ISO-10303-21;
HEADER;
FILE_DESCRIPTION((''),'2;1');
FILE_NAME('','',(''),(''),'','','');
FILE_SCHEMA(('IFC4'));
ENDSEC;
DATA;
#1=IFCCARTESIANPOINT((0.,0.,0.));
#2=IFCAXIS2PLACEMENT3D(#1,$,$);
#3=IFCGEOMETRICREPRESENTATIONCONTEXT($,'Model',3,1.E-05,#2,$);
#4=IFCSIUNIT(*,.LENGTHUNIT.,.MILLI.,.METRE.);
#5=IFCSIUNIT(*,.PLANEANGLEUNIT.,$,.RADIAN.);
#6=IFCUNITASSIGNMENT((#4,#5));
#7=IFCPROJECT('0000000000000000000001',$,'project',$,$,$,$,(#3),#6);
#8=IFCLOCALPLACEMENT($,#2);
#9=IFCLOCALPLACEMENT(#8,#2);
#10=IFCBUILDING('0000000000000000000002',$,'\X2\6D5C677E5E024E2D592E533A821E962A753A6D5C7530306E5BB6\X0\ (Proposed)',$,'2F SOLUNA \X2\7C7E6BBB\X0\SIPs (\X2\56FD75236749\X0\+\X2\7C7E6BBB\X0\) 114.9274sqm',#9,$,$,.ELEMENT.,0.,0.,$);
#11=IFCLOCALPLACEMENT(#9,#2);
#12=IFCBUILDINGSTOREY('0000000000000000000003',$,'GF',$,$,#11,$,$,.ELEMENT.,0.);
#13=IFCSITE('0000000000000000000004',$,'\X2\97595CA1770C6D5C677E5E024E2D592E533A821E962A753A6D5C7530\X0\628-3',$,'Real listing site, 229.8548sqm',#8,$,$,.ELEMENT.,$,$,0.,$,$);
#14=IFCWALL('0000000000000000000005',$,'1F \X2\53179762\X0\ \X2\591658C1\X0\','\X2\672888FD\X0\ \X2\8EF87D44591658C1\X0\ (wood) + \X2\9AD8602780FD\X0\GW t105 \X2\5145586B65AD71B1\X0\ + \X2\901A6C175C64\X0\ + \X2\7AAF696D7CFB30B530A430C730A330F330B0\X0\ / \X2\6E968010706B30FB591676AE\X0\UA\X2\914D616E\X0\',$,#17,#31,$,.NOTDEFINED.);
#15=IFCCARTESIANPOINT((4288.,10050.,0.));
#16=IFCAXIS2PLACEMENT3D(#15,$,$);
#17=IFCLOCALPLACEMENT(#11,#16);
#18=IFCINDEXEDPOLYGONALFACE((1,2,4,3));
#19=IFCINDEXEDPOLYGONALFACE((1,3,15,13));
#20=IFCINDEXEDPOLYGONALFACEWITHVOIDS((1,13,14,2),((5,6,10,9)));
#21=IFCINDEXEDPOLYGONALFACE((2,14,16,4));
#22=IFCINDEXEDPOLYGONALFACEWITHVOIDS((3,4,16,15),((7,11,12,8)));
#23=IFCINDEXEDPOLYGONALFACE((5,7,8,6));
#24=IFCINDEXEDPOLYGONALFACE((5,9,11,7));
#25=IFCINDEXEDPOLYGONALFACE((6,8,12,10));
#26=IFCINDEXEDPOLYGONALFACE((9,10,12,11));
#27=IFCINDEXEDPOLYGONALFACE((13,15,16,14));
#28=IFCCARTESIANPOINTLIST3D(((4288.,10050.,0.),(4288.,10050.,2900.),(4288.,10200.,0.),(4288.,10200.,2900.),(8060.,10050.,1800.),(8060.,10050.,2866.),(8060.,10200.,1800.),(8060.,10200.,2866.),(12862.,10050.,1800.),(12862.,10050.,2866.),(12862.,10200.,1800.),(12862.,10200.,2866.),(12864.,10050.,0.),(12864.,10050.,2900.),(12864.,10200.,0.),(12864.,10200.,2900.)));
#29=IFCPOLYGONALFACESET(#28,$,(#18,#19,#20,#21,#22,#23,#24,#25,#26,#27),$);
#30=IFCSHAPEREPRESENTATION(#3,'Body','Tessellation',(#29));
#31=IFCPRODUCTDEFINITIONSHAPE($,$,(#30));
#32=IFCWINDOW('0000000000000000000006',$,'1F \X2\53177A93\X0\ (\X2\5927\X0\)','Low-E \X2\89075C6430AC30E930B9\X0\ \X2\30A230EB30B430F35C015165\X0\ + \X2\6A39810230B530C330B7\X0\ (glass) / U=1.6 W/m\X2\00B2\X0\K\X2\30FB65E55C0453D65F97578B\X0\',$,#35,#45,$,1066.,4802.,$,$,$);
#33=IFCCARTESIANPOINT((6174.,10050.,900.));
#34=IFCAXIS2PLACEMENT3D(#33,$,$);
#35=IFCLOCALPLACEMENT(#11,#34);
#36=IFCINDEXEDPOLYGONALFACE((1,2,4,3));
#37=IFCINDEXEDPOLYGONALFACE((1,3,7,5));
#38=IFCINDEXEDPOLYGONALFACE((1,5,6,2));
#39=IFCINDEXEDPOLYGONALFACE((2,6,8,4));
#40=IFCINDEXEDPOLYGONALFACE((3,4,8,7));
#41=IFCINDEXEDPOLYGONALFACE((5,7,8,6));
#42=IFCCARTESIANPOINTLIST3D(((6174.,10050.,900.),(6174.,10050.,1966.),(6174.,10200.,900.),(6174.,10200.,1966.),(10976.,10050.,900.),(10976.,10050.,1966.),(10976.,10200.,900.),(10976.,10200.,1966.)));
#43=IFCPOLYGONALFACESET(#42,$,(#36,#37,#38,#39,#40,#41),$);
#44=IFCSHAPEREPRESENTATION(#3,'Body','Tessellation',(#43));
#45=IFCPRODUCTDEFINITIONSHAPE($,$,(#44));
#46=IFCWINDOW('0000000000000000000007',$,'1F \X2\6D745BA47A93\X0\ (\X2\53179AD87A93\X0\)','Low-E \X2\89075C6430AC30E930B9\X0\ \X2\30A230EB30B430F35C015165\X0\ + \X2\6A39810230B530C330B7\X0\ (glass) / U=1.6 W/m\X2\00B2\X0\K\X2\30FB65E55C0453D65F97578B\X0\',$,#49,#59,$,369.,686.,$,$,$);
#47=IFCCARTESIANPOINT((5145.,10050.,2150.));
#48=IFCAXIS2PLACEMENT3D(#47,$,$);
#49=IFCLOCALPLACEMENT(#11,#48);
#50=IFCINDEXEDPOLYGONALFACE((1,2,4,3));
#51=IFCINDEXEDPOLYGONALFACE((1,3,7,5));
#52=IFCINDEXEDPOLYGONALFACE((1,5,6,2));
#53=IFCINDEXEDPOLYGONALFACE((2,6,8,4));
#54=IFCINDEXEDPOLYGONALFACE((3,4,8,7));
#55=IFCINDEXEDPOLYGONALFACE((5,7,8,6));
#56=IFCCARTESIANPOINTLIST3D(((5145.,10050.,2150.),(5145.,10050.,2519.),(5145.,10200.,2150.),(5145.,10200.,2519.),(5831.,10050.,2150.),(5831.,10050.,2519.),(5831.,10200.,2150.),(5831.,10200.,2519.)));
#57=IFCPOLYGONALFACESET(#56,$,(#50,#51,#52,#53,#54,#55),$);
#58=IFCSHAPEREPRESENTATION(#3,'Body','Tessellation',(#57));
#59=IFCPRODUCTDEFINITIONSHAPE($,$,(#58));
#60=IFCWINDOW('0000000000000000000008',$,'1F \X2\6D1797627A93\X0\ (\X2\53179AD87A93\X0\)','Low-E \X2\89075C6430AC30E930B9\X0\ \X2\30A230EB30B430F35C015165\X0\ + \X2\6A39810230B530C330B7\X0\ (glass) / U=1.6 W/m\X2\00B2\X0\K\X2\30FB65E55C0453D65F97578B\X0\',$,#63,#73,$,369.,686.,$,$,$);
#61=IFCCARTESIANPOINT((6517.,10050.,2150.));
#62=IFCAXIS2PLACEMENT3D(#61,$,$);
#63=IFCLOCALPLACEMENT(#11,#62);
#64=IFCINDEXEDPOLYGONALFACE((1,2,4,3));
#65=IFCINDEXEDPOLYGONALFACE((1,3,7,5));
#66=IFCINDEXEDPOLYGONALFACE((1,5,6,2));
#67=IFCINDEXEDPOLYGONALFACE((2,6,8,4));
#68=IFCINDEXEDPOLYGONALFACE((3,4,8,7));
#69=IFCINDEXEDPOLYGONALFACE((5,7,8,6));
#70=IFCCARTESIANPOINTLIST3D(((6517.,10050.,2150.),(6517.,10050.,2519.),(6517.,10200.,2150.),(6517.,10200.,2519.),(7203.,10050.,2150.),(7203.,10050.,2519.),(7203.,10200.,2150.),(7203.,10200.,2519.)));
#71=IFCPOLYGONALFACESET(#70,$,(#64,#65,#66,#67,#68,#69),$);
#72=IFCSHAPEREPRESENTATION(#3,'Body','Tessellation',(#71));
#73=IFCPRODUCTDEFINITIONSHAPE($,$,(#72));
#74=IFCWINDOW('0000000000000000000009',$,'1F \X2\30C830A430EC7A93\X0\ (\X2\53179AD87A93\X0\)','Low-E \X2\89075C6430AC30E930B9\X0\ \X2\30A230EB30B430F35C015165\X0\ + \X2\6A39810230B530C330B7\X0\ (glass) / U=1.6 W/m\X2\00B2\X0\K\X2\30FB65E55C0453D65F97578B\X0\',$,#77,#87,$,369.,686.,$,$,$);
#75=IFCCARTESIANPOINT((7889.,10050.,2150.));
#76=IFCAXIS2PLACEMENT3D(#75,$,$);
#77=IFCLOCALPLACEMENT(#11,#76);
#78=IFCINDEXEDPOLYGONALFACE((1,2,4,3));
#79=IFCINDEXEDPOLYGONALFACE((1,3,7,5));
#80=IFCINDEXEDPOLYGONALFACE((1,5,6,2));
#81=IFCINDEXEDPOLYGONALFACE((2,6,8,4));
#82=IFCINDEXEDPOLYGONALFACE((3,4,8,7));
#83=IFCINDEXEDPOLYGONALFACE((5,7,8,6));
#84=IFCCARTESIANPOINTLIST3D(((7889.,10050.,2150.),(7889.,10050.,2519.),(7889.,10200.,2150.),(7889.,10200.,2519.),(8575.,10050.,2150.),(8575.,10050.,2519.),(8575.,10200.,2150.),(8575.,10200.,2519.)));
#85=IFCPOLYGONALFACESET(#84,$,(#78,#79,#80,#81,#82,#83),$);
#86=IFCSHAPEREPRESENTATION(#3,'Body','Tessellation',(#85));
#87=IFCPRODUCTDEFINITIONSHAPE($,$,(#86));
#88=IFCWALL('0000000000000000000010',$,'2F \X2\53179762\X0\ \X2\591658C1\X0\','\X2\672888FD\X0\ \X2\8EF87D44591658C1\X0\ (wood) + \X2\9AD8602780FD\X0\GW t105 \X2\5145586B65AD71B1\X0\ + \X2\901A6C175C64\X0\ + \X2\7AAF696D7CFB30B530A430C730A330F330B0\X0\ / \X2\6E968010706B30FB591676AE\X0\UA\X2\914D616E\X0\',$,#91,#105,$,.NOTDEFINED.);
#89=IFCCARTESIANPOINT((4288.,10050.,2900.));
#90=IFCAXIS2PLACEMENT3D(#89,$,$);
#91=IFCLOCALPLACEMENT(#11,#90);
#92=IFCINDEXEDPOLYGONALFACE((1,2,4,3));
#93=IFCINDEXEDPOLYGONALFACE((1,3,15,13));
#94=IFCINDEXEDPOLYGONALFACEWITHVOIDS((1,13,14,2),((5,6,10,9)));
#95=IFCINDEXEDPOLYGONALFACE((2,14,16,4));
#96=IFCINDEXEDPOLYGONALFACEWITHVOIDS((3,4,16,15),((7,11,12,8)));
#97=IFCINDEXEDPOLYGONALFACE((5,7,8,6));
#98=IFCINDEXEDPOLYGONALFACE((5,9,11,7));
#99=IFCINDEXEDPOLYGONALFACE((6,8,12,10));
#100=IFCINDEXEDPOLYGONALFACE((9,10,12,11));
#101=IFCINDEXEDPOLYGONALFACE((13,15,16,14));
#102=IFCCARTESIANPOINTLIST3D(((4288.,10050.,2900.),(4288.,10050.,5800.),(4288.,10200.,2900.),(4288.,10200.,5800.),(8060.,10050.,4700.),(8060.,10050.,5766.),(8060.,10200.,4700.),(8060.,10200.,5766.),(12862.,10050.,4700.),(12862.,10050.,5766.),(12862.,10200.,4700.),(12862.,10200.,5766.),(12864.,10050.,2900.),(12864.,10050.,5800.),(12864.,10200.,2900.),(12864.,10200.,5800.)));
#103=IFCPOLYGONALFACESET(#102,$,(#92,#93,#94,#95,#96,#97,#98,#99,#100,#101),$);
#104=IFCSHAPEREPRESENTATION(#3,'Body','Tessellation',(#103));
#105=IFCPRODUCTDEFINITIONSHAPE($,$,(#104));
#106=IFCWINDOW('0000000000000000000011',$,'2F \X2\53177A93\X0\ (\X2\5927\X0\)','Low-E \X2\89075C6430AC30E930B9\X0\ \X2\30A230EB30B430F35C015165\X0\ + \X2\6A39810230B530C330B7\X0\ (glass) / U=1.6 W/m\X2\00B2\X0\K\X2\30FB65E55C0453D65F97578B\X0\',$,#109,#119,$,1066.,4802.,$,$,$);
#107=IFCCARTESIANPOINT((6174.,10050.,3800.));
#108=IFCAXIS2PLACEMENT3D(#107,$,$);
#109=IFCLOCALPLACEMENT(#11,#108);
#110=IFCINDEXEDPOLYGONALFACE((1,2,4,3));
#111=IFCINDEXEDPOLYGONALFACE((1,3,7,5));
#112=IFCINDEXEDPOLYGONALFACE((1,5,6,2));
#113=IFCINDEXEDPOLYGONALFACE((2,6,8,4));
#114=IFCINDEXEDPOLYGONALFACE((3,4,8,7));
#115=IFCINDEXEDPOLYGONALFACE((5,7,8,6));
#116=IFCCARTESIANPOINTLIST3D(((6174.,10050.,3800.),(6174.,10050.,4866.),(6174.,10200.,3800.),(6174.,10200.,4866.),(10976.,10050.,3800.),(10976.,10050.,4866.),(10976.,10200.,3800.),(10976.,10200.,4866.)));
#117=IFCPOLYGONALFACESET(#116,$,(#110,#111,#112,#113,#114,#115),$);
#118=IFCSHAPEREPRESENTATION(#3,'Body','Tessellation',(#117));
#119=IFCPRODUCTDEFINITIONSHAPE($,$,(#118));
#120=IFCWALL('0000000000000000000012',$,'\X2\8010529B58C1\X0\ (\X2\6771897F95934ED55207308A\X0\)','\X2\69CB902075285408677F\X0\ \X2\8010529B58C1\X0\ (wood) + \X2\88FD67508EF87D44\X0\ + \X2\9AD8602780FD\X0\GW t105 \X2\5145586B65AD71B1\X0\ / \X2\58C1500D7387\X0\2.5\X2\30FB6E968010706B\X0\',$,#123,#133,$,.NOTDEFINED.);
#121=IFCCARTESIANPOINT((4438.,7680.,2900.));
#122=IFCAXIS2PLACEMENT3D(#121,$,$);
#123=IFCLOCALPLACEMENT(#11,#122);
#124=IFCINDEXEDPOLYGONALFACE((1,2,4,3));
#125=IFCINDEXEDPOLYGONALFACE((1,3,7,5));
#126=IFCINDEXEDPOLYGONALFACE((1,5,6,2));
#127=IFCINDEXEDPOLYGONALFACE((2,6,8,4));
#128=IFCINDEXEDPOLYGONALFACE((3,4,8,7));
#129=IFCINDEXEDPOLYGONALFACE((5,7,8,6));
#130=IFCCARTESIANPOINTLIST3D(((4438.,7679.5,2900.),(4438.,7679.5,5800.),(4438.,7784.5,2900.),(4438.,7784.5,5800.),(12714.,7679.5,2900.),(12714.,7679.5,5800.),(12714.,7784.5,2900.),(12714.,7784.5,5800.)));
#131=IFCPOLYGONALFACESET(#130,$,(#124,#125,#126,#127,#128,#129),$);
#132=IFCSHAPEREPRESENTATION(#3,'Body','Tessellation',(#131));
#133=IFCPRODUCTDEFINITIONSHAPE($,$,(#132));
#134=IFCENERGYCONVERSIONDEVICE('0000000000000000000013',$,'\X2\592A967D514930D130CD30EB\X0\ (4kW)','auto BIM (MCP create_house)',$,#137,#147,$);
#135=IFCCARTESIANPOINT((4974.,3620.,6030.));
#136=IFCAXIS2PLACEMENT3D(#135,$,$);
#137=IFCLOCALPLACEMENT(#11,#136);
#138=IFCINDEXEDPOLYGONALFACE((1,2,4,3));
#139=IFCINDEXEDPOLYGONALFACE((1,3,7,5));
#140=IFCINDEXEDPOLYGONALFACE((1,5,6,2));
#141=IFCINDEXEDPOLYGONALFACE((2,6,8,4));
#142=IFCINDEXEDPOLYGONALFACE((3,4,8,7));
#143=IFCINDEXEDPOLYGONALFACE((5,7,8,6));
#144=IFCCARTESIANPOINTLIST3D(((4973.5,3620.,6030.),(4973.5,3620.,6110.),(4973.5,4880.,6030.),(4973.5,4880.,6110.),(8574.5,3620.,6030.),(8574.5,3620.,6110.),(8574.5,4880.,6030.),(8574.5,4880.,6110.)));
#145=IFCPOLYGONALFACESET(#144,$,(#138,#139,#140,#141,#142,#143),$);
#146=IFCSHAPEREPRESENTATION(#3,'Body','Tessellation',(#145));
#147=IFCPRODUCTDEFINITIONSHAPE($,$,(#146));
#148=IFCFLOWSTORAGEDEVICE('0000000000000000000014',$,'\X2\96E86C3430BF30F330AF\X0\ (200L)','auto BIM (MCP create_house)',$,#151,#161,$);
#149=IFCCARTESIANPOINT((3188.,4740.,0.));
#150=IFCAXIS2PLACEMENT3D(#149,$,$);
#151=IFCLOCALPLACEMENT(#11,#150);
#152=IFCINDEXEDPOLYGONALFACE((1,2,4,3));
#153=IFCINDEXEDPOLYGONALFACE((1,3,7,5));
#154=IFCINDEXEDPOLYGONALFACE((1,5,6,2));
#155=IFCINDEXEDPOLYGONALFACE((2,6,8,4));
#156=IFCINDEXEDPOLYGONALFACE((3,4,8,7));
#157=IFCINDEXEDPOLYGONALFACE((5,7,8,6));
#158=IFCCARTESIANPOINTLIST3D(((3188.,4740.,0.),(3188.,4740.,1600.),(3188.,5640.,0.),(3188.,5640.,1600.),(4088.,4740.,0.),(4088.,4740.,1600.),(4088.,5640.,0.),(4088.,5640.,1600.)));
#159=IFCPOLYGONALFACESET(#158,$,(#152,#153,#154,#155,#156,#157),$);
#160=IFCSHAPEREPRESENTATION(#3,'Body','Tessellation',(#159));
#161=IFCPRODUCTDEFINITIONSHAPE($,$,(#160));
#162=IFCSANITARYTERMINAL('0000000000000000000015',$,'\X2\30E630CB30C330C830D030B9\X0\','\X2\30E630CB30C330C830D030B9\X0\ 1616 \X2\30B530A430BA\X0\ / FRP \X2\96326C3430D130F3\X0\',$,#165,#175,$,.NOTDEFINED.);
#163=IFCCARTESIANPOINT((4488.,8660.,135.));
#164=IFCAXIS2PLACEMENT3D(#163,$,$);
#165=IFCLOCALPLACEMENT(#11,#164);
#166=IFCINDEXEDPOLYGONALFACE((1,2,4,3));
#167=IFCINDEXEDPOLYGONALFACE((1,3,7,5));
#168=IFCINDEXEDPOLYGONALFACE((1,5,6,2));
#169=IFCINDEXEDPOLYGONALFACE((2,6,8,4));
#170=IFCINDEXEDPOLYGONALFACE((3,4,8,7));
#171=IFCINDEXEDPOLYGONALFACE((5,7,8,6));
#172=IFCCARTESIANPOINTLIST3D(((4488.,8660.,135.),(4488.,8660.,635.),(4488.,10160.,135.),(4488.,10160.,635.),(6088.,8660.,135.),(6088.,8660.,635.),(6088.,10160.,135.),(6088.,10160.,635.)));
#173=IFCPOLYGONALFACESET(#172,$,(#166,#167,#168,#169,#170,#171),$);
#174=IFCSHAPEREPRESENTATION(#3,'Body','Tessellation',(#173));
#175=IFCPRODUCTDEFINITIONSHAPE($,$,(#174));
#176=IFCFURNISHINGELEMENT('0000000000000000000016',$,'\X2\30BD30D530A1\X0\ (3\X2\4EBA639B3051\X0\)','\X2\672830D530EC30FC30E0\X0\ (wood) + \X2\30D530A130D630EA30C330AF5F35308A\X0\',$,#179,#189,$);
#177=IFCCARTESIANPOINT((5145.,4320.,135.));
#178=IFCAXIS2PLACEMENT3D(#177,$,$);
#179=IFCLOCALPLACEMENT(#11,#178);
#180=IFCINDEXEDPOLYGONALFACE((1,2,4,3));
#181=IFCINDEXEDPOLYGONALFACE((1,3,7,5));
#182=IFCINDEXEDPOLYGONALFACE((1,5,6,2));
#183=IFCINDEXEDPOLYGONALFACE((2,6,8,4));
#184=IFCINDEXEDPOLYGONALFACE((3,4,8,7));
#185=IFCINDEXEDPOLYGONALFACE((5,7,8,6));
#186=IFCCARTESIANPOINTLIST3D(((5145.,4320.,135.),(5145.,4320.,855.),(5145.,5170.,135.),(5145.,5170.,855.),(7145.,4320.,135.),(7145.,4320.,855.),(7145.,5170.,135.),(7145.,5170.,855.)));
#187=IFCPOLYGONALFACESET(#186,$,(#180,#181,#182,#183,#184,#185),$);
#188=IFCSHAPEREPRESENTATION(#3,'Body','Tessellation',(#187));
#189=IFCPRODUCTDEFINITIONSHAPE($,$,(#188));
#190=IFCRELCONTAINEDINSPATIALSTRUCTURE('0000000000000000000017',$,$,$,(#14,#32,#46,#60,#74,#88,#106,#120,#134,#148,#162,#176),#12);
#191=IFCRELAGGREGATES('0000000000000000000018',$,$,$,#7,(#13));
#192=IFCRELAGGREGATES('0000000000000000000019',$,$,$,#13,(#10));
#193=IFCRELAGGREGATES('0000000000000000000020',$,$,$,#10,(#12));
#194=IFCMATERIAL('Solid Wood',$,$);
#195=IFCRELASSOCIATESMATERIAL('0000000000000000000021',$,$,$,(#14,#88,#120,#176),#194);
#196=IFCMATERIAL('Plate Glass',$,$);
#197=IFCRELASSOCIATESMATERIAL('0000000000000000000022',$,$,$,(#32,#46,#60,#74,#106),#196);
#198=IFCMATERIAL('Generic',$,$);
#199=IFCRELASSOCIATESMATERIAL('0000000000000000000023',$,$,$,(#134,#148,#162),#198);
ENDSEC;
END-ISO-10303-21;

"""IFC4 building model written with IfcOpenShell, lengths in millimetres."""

from ifc_helpers import new_model, si_unit, frame, frame_2d, origin, place, context, project, spatial, rectangle, extrude, material, element, fill, save


model = new_model("IFC4")

# Units and contexts
model_context = context("Model", 3, precision=1e-05, world=origin())
ifc_project = project(units=[si_unit("LENGTHUNIT", "METRE", prefix="MILLI"), si_unit("PLANEANGLEUNIT", "RADIAN")], contexts=[model_context])

# Site, building, storey
site_placement = place(None, origin())
site = spatial("IfcSite", under=ifc_project, at=site_placement, Name="静岡県浜松市中央区舞阪町浜田628-3", ObjectType="Real listing site, 229.8548sqm", CompositionType="ELEMENT", RefElevation=0.0)
building_placement = place(site_placement, origin())
building = spatial("IfcBuilding", under=site, at=building_placement, Name="浜松市中央区舞阪町浜田の家 (Proposed)", ObjectType="2F SOLUNA 籾殻SIPs (国産杉+籾殻) 114.9274sqm", CompositionType="ELEMENT", ElevationOfRefHeight=0.0, ElevationOfTerrain=0.0)
storey_placement = place(building_placement, origin())
storey = spatial("IfcBuildingStorey", under=building, at=storey_placement, Name="GF", CompositionType="ELEMENT", Elevation=0.0)

# Wall, openings, windows
ifc_material_1 = material(Name="Solid Wood")
wall_1_placement = place(storey_placement, frame((4288.0, 10050.0, 0.0)))
wall_1 = element("IfcWall", 1, at=wall_1_placement, inside=storey, material=ifc_material_1, Name="1F 北面 外壁", Description="木製 軸組外壁 (wood) + 高性能GW t105 充填断熱 + 通気層 + 窯業系サイディング / 準耐火・外皮UA配慮", PredefinedType="NOTDEFINED", context=model_context, shape_type="SweptSolid", body=[
    extrude(rectangle(XDim=8576.0, YDim=150.0, at=frame_2d((4288.0, 75.0))), frame((4288.0, 10050.0, 0.0)), (0.0, 0.0, 1.0), 2900.0),
])
opening_1_placement = place(storey_placement, frame((6174.0, 10050.0, 900.0)))
opening_1 = element("IfcOpeningElement", 2, at=opening_1_placement, cuts=wall_1, PredefinedType="NOTDEFINED", context=model_context, shape_type="SweptSolid", body=[
    extrude(rectangle(XDim=4802.0, YDim=150.0, at=frame_2d((2401.0, 75.0))), frame((6174.0, 10050.0, 900.0)), (0.0, 0.0, 1.0), 1066.0),
])
opening_2_placement = place(storey_placement, frame((5145.0, 10050.0, 2150.0)))
opening_2 = element("IfcOpeningElement", 3, at=opening_2_placement, cuts=wall_1, PredefinedType="NOTDEFINED", context=model_context, shape_type="SweptSolid", body=[
    extrude(rectangle(XDim=686.0, YDim=150.0, at=frame_2d((343.0, 75.0))), frame((5145.0, 10050.0, 2150.0)), (0.0, 0.0, 1.0), 369.0),
])
opening_3_placement = place(storey_placement, frame((6517.0, 10050.0, 2150.0)))
opening_3 = element("IfcOpeningElement", 4, at=opening_3_placement, cuts=wall_1, PredefinedType="NOTDEFINED", context=model_context, shape_type="SweptSolid", body=[
    extrude(rectangle(XDim=686.0, YDim=150.0, at=frame_2d((343.0, 75.0))), frame((6517.0, 10050.0, 2150.0)), (0.0, 0.0, 1.0), 369.0),
])
opening_4_placement = place(storey_placement, frame((7889.0, 10050.0, 2150.0)))
opening_4 = element("IfcOpeningElement", 5, at=opening_4_placement, cuts=wall_1, PredefinedType="NOTDEFINED", context=model_context, shape_type="SweptSolid", body=[
    extrude(rectangle(XDim=686.0, YDim=150.0, at=frame_2d((343.0, 75.0))), frame((7889.0, 10050.0, 2150.0)), (0.0, 0.0, 1.0), 369.0),
])
ifc_material_2 = material(Name="Plate Glass")
window_1_placement = place(storey_placement, frame((6174.0, 10050.0, 900.0)))
window_1 = element("IfcWindow", 6, at=window_1_placement, inside=storey, material=ifc_material_2, Name="1F 北窓 (大)", Description="Low-E 複層ガラス アルゴン封入 + 樹脂サッシ (glass) / U=1.6 W/m²K・日射取得型", OverallHeight=1066.0, OverallWidth=4802.0, context=model_context, shape_type="SweptSolid", body=[
    extrude(rectangle(XDim=4802.0, YDim=150.0, at=frame_2d((2401.0, 75.0))), frame((6174.0, 10050.0, 900.0)), (0.0, 0.0, 1.0), 1066.0),
])
fill(opening_1, window_1)
window_2_placement = place(storey_placement, frame((5145.0, 10050.0, 2150.0)))
window_2 = element("IfcWindow", 7, at=window_2_placement, inside=storey, material=ifc_material_2, Name="1F 浴室窓 (北高窓)", Description="Low-E 複層ガラス アルゴン封入 + 樹脂サッシ (glass) / U=1.6 W/m²K・日射取得型", OverallHeight=369.0, OverallWidth=686.0, context=model_context, shape_type="SweptSolid", body=[
    extrude(rectangle(XDim=686.0, YDim=150.0, at=frame_2d((343.0, 75.0))), frame((5145.0, 10050.0, 2150.0)), (0.0, 0.0, 1.0), 369.0),
])
fill(opening_2, window_2)
window_3_placement = place(storey_placement, frame((6517.0, 10050.0, 2150.0)))
window_3 = element("IfcWindow", 8, at=window_3_placement, inside=storey, material=ifc_material_2, Name="1F 洗面窓 (北高窓)", Description="Low-E 複層ガラス アルゴン封入 + 樹脂サッシ (glass) / U=1.6 W/m²K・日射取得型", OverallHeight=369.0, OverallWidth=686.0, context=model_context, shape_type="SweptSolid", body=[
    extrude(rectangle(XDim=686.0, YDim=150.0, at=frame_2d((343.0, 75.0))), frame((6517.0, 10050.0, 2150.0)), (0.0, 0.0, 1.0), 369.0),
])
fill(opening_3, window_3)
window_4_placement = place(storey_placement, frame((7889.0, 10050.0, 2150.0)))
window_4 = element("IfcWindow", 9, at=window_4_placement, inside=storey, material=ifc_material_2, Name="1F トイレ窓 (北高窓)", Description="Low-E 複層ガラス アルゴン封入 + 樹脂サッシ (glass) / U=1.6 W/m²K・日射取得型", OverallHeight=369.0, OverallWidth=686.0, context=model_context, shape_type="SweptSolid", body=[
    extrude(rectangle(XDim=686.0, YDim=150.0, at=frame_2d((343.0, 75.0))), frame((7889.0, 10050.0, 2150.0)), (0.0, 0.0, 1.0), 369.0),
])
fill(opening_4, window_4)

# Wall, opening, window
wall_2_placement = place(storey_placement, frame((4288.0, 10050.0, 2900.0)))
wall_2 = element("IfcWall", 10, at=wall_2_placement, inside=storey, material=ifc_material_1, Name="2F 北面 外壁", Description="木製 軸組外壁 (wood) + 高性能GW t105 充填断熱 + 通気層 + 窯業系サイディング / 準耐火・外皮UA配慮", PredefinedType="NOTDEFINED", context=model_context, shape_type="SweptSolid", body=[
    extrude(rectangle(XDim=8576.0, YDim=150.0, at=frame_2d((4288.0, 75.0))), frame((4288.0, 10050.0, 2900.0)), (0.0, 0.0, 1.0), 2900.0),
])
opening_5_placement = place(storey_placement, frame((6174.0, 10050.0, 3800.0)))
opening_5 = element("IfcOpeningElement", 11, at=opening_5_placement, cuts=wall_2, PredefinedType="NOTDEFINED", context=model_context, shape_type="SweptSolid", body=[
    extrude(rectangle(XDim=4802.0, YDim=150.0, at=frame_2d((2401.0, 75.0))), frame((6174.0, 10050.0, 3800.0)), (0.0, 0.0, 1.0), 1066.0),
])
window_5_placement = place(storey_placement, frame((6174.0, 10050.0, 3800.0)))
window_5 = element("IfcWindow", 12, at=window_5_placement, inside=storey, material=ifc_material_2, Name="2F 北窓 (大)", Description="Low-E 複層ガラス アルゴン封入 + 樹脂サッシ (glass) / U=1.6 W/m²K・日射取得型", OverallHeight=1066.0, OverallWidth=4802.0, context=model_context, shape_type="SweptSolid", body=[
    extrude(rectangle(XDim=4802.0, YDim=150.0, at=frame_2d((2401.0, 75.0))), frame((6174.0, 10050.0, 3800.0)), (0.0, 0.0, 1.0), 1066.0),
])
fill(opening_5, window_5)

# Wall
wall_3_placement = place(storey_placement, frame((4438.0, 7680.0, 2900.0)))
element("IfcWall", 13, at=wall_3_placement, inside=storey, material=ifc_material_1, Name="耐力壁 (東西間仕切り)", Description="構造用合板 耐力壁 (wood) + 製材軸組 + 高性能GW t105 充填断熱 / 壁倍率2.5・準耐火", PredefinedType="NOTDEFINED", context=model_context, shape_type="SweptSolid", body=[
    extrude(rectangle(XDim=8276.0, YDim=105.0, at=frame_2d((4138.0, 52.0))), frame((4438.0, 7680.0, 2900.0)), (0.0, 0.0, 1.0), 2900.0),
])

# Energy conversion device
ifc_material_3 = material(Name="Generic")
energy_conversion_device_placement = place(storey_placement, frame((4974.0, 3620.0, 6030.0)))
element("IfcEnergyConversionDevice", 14, at=energy_conversion_device_placement, inside=storey, material=ifc_material_3, Name="太陽光パネル (4kW)", Description="auto BIM (MCP create_house)", context=model_context, shape_type="SweptSolid", body=[
    extrude(rectangle(XDim=3601.0, YDim=1260.0, at=frame_2d((1800.0, 630.0))), frame((4974.0, 3620.0, 6030.0)), (0.0, 0.0, 1.0), 80.0),
])

# Flow storage device
flow_storage_device_placement = place(storey_placement, frame((3188.0, 4740.0, 0.0)))
element("IfcFlowStorageDevice", 15, at=flow_storage_device_placement, inside=storey, material=ifc_material_3, Name="雨水タンク (200L)", Description="auto BIM (MCP create_house)", context=model_context, shape_type="SweptSolid", body=[
    extrude(rectangle(XDim=900.0, YDim=900.0, at=frame_2d((450.0, 450.0))), frame((3188.0, 4740.0, 0.0)), (0.0, 0.0, 1.0), 1600.0),
])

# Sanitary terminal
sanitary_terminal_placement = place(storey_placement, frame((4488.0, 8660.0, 135.0)))
element("IfcSanitaryTerminal", 16, at=sanitary_terminal_placement, inside=storey, material=ifc_material_3, Name="ユニットバス", Description="ユニットバス 1616 サイズ / FRP 防水パン", PredefinedType="NOTDEFINED", context=model_context, shape_type="SweptSolid", body=[
    extrude(rectangle(XDim=1600.0, YDim=1500.0, at=frame_2d((800.0, 750.0))), frame((4488.0, 8660.0, 135.0)), (0.0, 0.0, 1.0), 500.0),
])

# Furnishing element
furnishing_1_placement = place(storey_placement, frame((5145.0, 4320.0, 135.0)))
element("IfcFurnishingElement", 17, at=furnishing_1_placement, inside=storey, material=ifc_material_1, Name="ソファ (3人掛け)", Description="木フレーム (wood) + ファブリック張り", context=model_context, shape_type="SweptSolid", body=[
    extrude(rectangle(XDim=2000.0, YDim=850.0, at=frame_2d((1000.0, 425.0))), frame((5145.0, 4320.0, 135.0)), (0.0, 0.0, 1.0), 720.0),
])

save(model, "model.ifc")
